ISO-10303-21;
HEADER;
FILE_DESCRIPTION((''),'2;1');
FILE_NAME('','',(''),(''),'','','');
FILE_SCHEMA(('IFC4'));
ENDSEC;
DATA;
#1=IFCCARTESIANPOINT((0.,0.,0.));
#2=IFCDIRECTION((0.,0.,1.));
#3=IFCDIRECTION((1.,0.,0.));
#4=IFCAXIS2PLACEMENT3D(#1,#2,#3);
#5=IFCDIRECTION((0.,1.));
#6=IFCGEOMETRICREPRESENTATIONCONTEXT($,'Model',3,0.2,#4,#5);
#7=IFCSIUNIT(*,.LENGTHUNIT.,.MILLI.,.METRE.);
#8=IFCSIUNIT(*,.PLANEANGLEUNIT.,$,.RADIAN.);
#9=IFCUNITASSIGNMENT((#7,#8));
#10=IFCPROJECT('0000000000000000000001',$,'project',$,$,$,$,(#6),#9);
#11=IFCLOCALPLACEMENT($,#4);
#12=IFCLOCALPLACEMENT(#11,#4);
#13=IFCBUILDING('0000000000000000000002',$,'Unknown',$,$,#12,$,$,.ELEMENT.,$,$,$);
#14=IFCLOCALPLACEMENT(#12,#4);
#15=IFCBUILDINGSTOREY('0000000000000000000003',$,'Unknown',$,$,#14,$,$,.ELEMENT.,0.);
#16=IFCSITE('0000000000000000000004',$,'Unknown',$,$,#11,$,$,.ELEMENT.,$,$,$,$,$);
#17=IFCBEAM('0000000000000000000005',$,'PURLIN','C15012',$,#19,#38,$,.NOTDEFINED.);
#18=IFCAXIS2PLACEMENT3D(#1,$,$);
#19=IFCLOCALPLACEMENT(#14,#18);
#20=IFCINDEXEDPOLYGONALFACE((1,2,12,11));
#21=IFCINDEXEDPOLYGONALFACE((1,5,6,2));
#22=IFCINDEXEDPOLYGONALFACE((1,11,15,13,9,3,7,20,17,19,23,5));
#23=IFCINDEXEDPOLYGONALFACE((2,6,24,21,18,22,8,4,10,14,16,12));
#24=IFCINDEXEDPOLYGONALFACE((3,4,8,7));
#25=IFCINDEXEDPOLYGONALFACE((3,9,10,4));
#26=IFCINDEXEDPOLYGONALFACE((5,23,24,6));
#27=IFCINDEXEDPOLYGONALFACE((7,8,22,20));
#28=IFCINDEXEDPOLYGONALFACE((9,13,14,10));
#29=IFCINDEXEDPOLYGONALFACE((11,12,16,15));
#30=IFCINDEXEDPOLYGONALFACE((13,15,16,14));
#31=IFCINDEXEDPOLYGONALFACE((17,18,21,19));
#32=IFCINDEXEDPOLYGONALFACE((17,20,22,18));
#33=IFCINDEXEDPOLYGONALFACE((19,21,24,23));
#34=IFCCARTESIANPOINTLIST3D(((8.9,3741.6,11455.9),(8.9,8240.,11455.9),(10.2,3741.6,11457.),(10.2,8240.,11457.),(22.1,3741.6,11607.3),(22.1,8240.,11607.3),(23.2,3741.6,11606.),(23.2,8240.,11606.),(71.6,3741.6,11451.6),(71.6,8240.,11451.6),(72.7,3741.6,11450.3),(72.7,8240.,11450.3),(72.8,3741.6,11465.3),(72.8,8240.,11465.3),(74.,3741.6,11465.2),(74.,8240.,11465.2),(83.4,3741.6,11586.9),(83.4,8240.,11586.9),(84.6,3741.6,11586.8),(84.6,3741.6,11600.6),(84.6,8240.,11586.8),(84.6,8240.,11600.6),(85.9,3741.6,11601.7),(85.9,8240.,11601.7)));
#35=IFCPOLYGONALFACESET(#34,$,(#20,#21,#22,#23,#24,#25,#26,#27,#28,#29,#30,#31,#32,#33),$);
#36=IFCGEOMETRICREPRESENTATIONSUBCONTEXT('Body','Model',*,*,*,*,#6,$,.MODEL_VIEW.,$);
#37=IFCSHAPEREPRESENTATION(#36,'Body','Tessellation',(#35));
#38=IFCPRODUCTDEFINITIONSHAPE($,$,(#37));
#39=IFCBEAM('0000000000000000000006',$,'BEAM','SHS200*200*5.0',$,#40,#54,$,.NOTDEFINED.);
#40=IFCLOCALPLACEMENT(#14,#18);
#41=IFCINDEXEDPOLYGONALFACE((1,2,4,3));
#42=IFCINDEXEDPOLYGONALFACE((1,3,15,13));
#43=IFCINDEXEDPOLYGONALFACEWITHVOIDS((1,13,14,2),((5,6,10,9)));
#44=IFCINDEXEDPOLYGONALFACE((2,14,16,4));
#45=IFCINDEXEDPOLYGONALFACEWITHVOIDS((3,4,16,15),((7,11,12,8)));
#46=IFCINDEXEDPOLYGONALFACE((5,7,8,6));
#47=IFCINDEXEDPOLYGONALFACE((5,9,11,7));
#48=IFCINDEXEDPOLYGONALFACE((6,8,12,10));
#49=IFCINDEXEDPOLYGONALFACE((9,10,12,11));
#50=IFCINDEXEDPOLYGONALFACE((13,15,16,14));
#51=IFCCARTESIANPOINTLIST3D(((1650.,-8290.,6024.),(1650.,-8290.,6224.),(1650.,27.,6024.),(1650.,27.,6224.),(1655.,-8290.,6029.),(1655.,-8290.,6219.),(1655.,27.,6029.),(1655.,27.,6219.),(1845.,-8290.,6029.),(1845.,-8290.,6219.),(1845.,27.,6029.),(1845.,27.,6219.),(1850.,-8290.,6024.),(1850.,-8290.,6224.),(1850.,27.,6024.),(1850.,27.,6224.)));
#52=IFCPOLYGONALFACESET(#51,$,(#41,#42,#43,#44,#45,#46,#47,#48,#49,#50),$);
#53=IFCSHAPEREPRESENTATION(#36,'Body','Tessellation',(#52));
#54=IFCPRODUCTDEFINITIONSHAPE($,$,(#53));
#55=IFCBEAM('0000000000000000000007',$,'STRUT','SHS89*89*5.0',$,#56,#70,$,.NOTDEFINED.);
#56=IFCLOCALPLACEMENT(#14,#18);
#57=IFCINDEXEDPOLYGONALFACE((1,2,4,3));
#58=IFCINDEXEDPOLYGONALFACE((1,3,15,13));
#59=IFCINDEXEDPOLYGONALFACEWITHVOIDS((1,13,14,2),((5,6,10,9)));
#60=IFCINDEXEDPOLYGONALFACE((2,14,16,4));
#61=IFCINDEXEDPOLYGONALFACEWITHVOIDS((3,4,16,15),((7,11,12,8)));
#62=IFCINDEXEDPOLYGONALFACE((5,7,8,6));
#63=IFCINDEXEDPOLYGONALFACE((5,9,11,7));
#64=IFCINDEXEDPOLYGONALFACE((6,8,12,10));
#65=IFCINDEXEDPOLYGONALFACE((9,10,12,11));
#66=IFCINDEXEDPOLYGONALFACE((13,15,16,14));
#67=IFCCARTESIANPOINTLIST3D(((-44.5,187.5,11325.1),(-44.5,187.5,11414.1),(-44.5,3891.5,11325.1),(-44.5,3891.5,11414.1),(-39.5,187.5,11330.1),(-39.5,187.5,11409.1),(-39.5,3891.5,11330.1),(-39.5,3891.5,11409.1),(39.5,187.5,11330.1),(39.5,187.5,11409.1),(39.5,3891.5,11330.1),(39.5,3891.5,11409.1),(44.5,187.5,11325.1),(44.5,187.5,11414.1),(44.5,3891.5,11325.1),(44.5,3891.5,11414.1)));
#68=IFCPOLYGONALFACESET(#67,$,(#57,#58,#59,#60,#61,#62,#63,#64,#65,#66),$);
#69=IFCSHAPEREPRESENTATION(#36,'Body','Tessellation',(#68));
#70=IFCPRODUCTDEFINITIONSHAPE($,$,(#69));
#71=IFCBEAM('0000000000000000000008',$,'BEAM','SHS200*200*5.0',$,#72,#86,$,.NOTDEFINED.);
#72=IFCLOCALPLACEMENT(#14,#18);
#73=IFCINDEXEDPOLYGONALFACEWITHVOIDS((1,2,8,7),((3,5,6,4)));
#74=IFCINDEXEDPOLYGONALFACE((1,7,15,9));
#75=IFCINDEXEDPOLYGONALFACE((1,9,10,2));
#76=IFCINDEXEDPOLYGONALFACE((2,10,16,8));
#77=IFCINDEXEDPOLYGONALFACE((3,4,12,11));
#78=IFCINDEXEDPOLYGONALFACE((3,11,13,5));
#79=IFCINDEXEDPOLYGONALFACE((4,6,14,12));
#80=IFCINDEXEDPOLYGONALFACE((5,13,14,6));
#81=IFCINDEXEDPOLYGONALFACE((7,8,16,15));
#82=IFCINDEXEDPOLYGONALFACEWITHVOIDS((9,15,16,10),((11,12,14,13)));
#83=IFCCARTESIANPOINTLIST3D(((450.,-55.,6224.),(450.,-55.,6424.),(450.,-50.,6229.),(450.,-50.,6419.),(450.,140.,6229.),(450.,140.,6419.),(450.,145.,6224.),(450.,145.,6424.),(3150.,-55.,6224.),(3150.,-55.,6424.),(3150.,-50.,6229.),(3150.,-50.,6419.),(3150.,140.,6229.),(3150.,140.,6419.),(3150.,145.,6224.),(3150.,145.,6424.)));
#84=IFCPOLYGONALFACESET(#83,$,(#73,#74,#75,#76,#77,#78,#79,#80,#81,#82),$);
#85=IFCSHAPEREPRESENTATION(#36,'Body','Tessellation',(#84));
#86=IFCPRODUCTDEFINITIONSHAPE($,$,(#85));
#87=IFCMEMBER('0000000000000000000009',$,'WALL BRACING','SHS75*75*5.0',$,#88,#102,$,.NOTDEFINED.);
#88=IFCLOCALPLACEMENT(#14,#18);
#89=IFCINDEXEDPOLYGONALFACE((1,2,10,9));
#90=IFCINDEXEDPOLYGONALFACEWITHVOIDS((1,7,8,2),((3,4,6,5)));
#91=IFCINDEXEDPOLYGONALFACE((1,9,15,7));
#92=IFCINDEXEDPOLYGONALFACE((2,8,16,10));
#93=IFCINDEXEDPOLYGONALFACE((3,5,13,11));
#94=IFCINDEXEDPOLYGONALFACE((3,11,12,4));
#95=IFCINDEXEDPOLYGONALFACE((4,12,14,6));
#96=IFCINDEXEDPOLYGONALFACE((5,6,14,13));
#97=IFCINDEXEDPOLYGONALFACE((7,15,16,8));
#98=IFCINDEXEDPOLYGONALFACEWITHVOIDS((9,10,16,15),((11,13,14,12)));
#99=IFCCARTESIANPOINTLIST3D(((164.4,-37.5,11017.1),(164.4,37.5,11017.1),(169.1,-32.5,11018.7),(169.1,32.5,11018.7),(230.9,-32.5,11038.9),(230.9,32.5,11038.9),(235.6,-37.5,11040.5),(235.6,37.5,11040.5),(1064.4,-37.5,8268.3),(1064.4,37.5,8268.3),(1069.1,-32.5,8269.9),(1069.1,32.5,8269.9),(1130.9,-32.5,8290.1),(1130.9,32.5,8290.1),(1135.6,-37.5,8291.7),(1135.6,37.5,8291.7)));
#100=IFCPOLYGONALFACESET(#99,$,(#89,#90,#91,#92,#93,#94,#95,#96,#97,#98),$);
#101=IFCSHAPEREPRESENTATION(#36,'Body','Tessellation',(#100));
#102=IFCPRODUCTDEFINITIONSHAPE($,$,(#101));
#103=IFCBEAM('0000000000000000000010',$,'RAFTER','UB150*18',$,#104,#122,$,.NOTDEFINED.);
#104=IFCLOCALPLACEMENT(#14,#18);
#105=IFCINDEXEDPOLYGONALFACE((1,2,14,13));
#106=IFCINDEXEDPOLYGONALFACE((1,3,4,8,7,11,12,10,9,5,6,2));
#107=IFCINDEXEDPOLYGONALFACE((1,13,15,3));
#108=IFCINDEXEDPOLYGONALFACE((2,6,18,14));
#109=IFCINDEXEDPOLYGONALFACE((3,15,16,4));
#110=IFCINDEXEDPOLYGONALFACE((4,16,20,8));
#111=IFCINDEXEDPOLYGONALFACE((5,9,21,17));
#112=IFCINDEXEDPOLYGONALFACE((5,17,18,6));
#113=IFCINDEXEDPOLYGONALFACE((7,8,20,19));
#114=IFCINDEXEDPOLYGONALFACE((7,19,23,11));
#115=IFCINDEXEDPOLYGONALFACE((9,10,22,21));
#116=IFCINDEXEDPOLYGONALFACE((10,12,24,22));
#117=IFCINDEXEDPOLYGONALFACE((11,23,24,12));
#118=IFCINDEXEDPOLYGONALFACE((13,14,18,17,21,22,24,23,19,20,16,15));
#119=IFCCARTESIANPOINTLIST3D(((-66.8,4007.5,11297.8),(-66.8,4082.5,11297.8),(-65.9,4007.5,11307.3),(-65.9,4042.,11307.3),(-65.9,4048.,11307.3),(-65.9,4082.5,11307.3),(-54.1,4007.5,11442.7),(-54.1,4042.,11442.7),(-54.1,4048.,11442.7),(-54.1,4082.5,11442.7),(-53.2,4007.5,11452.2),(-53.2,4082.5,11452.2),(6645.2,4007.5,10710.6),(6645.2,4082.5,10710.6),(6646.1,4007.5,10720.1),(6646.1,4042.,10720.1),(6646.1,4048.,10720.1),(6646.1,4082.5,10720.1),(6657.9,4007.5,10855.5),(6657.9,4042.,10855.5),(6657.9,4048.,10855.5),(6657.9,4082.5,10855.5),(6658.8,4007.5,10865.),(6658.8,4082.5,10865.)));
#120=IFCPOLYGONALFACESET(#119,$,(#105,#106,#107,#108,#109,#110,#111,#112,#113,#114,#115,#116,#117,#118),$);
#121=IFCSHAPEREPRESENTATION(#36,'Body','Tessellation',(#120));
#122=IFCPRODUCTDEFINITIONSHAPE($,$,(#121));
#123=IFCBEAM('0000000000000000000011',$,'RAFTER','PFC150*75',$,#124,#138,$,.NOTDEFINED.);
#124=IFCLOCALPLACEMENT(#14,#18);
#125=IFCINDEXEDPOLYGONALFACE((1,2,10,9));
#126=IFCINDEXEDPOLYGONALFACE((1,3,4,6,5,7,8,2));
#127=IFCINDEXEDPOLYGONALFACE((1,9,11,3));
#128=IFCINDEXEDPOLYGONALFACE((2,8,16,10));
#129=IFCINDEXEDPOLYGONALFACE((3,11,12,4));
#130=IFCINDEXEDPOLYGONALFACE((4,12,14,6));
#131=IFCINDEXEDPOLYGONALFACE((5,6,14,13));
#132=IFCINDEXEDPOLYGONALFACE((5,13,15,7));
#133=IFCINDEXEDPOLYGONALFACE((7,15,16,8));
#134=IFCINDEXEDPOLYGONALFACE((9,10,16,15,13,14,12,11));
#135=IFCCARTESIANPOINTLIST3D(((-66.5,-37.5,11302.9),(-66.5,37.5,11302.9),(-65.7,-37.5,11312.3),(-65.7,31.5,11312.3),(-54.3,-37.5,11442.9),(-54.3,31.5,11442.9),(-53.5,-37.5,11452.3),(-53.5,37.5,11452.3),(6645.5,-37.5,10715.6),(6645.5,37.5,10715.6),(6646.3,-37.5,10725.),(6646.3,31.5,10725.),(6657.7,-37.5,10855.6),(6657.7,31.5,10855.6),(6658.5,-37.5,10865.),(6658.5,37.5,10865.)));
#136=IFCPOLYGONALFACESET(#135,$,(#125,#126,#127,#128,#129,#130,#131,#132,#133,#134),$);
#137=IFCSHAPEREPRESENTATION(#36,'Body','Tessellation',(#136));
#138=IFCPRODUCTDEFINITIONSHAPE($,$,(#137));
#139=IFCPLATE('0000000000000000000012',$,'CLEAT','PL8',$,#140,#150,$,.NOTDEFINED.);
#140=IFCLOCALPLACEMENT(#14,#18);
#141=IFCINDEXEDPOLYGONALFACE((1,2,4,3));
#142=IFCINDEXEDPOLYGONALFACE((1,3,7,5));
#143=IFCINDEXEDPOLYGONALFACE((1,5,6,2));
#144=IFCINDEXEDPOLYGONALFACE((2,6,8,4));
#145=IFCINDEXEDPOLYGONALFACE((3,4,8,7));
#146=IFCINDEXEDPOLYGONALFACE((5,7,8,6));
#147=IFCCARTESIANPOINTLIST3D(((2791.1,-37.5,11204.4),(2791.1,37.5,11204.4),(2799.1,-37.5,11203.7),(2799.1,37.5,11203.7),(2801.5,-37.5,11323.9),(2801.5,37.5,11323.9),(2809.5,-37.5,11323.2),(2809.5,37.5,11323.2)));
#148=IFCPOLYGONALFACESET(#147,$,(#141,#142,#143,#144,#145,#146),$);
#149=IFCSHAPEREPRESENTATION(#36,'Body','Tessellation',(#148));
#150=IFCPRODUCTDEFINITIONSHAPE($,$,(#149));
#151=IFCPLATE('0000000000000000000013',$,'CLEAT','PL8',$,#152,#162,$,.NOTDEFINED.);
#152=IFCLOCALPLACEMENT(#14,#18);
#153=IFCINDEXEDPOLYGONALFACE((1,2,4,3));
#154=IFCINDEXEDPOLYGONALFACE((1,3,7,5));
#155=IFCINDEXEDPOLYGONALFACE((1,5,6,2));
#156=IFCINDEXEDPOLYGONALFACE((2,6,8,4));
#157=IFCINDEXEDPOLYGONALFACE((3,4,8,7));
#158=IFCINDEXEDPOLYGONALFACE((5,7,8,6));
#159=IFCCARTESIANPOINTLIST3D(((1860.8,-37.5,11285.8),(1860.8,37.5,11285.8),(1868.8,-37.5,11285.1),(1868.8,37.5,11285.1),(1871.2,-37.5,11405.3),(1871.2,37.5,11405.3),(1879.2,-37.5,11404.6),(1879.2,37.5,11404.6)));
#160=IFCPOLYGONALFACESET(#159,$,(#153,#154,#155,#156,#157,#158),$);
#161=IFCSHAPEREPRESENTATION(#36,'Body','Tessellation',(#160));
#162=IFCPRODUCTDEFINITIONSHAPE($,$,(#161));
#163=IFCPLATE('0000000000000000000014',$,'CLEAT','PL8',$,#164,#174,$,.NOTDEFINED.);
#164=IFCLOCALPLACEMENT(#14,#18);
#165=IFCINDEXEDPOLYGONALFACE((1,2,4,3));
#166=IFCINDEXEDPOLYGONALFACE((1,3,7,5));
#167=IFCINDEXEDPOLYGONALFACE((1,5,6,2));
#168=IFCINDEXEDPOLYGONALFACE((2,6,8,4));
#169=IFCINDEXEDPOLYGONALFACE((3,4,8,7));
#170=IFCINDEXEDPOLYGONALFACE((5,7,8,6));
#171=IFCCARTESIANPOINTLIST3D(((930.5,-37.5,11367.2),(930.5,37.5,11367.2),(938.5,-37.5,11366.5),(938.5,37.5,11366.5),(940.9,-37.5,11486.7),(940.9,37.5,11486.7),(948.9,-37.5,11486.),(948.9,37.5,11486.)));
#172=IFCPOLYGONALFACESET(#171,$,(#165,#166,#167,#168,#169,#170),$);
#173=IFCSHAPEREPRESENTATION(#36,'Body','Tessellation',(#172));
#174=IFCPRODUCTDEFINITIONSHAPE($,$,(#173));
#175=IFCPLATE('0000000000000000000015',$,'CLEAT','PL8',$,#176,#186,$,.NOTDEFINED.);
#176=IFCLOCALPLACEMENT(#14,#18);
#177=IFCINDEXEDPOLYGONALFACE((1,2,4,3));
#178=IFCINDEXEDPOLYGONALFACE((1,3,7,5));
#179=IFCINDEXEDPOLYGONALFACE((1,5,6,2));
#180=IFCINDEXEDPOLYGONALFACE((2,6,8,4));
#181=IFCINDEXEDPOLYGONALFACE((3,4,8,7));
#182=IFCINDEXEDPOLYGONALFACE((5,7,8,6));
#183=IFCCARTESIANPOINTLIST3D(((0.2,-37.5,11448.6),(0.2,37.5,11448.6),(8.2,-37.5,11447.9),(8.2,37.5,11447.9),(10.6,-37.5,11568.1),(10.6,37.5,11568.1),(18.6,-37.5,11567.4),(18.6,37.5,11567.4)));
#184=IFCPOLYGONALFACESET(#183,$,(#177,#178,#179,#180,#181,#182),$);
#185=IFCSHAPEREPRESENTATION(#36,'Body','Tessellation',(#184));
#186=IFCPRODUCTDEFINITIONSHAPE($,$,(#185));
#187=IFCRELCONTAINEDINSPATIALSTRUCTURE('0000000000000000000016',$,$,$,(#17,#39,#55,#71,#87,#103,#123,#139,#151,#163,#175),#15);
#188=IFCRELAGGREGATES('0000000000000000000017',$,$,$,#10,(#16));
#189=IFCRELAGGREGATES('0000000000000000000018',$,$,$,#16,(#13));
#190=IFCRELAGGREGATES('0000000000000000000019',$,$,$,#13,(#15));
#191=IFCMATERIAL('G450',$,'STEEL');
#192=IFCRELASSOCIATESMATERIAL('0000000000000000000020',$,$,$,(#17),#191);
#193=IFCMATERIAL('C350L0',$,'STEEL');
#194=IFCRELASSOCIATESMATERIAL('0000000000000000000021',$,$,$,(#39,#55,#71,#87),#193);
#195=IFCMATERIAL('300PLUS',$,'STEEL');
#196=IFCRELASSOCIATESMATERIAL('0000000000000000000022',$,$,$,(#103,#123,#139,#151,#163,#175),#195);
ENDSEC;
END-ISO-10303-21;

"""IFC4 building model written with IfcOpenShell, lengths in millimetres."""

from ifc_helpers import new_model, si_unit, direction, frame, origin_with_axes, place, context, subcontext, project, spatial, line, indexed_curve, outline, extrude, material, element, save


model = new_model("IFC4")

# Units and contexts
model_context = context("Model", 3, precision=0.2, world=origin_with_axes(), true_north=direction((0.0, 1.0)))
body_context = subcontext(model_context, "Body", "Model", "MODEL_VIEW")
ifc_project = project(units=[si_unit("LENGTHUNIT", "METRE", prefix="MILLI"), si_unit("PLANEANGLEUNIT", "RADIAN")], contexts=[model_context])

# Site, building, storey
site_placement = place(None, origin_with_axes())
site = spatial("IfcSite", under=ifc_project, at=site_placement, Name="Unknown", CompositionType="ELEMENT")
building_placement = place(site_placement, origin_with_axes())
building = spatial("IfcBuilding", under=site, at=building_placement, Name="Unknown", CompositionType="ELEMENT")
storey_placement = place(building_placement, origin_with_axes())
storey = spatial("IfcBuildingStorey", under=building, at=storey_placement, Name="Unknown", CompositionType="ELEMENT", Elevation=0.0)

# Shared definitions
ifc_material_1 = material(Name="C350L0", Category="STEEL")

# Beams
ifc_material_2 = material(Name="G450", Category="STEEL")
for number, where, z_axis, x_axis, name in (
    (1, (47.4, 3741.6, 11528.8), (0.996195, 0.0, -0.087156), (0.0, 1.0, 0.0), "PURLIN"),
):
    element("IfcBeam", number, at=place(storey_placement, frame(where, z_axis=z_axis, x_axis=x_axis)), inside=storey, material=ifc_material_2, Name=name, Description="C15012", PredefinedType="NOTDEFINED", context=body_context, shape_type="SolidModel", body=[
        extrude(outline(indexed_curve([(32.0, -76.0), (32.0, -61.0), (30.8, -61.0), (30.8, -74.8), (-30.8, -74.8), (-30.8, 74.8), (30.8, 74.8), (30.8, 61.0), (32.0, 61.0), (32.0, 76.0), (-32.0, 76.0), (-32.0, -76.0)], segments=[line(1, 2, 3, 4, 5, 6, 7, 8, 9, 10, 11, 12, 1)])), frame((0.0, 0.0, 0.0), z_axis=(-1.0, 0.0, 0.0), x_axis=(0.0, 0.0, 1.0)), (0.0, 0.0, -1.0), 4498.4),
    ])
beam_1_placement = place(storey_placement, frame((1750.0, 27.0, 6124.0), z_axis=(0.0, 0.0, 1.0), x_axis=(0.0, -1.0, 0.0)))
element("IfcBeam", 2, at=beam_1_placement, inside=storey, material=ifc_material_1, Name="BEAM", Description="SHS200*200*5.0", PredefinedType="NOTDEFINED", context=body_context, shape_type="SolidModel", body=[
    extrude(outline(indexed_curve([(-100.0, -100.0), (100.0, -100.0), (100.0, 100.0), (-100.0, 100.0)], segments=[line(1, 2, 3, 4, 1)]), holes=[indexed_curve([(-95.0, -95.0), (-95.0, 95.0), (95.0, 95.0), (95.0, -95.0)], segments=[line(1, 2, 3, 4, 1)])]), frame((0.0, 0.0, 0.0), z_axis=(-1.0, 0.0, 0.0), x_axis=(0.0, 0.0, 1.0)), (0.0, 0.0, -1.0), 8317.0),
])
beam_2_placement = place(storey_placement, frame((0.0, 187.5, 11369.6), z_axis=(0.0, 0.0, 1.0), x_axis=(0.0, 1.0, 0.0)))
element("IfcBeam", 3, at=beam_2_placement, inside=storey, material=ifc_material_1, Name="STRUT", Description="SHS89*89*5.0", PredefinedType="NOTDEFINED", context=body_context, shape_type="SolidModel", body=[
    extrude(outline(indexed_curve([(-44.5, -44.5), (44.5, -44.5), (44.5, 44.5), (-44.5, 44.5)], segments=[line(1, 2, 3, 4, 1)]), holes=[indexed_curve([(-39.5, -39.5), (-39.5, 39.5), (39.5, 39.5), (39.5, -39.5)], segments=[line(1, 2, 3, 4, 1)])]), frame((0.0, 0.0, 0.0), z_axis=(-1.0, 0.0, 0.0), x_axis=(0.0, 0.0, 1.0)), (0.0, 0.0, -1.0), 3704.0),
])
beam_3_placement = place(storey_placement, frame((450.0, 45.0, 6324.0), z_axis=(0.0, 0.0, 1.0), x_axis=(1.0, 0.0, 0.0)))
element("IfcBeam", 4, at=beam_3_placement, inside=storey, material=ifc_material_1, Name="BEAM", Description="SHS200*200*5.0", PredefinedType="NOTDEFINED", context=body_context, shape_type="SolidModel", body=[
    extrude(outline(indexed_curve([(-100.0, -100.0), (100.0, -100.0), (100.0, 100.0), (-100.0, 100.0)], segments=[line(1, 2, 3, 4, 1)]), holes=[indexed_curve([(-95.0, -95.0), (-95.0, 95.0), (95.0, 95.0), (95.0, -95.0)], segments=[line(1, 2, 3, 4, 1)])]), frame((0.0, 0.0, 0.0), z_axis=(-1.0, 0.0, 0.0), x_axis=(0.0, 0.0, 1.0)), (0.0, 0.0, -1.0), 2700.0),
])

# Member
member_placement = place(storey_placement, frame((200.0, 0.0, 11028.8), z_axis=(0.950357, 0.0, 0.311162), x_axis=(0.311162, 0.0, -0.950357)))
element("IfcMember", 5, at=member_placement, inside=storey, material=ifc_material_1, Name="WALL BRACING", Description="SHS75*75*5.0", PredefinedType="NOTDEFINED", context=body_context, shape_type="SolidModel", body=[
    extrude(outline(indexed_curve([(-37.5, -37.5), (37.5, -37.5), (37.5, 37.5), (-37.5, 37.5)], segments=[line(1, 2, 3, 4, 1)]), holes=[indexed_curve([(-32.5, -32.5), (-32.5, 32.5), (32.5, 32.5), (32.5, -32.5)], segments=[line(1, 2, 3, 4, 1)])]), frame((0.0, 0.0, 0.0), z_axis=(-1.0, 0.0, 0.0), x_axis=(0.0, 0.0, 1.0)), (0.0, 0.0, -1.0), 2892.4),
])

# Beams
ifc_material_3 = material(Name="300PLUS", Category="STEEL")
beam_4_placement = place(storey_placement, frame((-60.0, 4045.0, 11375.0), z_axis=(0.0, -1.0, 0.0), x_axis=(0.996195, 0.0, -0.087152)))
element("IfcBeam", 6, at=beam_4_placement, inside=storey, material=ifc_material_3, Name="RAFTER", Description="UB150*18", PredefinedType="NOTDEFINED", context=body_context, shape_type="SolidModel", body=[
    extrude(outline(indexed_curve([(-37.5, -77.5), (37.5, -77.5), (37.5, -68.0), (3.0, -68.0), (3.0, 68.0), (37.5, 68.0), (37.5, 77.5), (-37.5, 77.5), (-37.5, 68.0), (-3.0, 68.0), (-3.0, -68.0), (-37.5, -68.0)], segments=[line(1, 2, 3, 4, 5, 6, 7, 8, 9, 10, 11, 12, 1)])), frame((0.0, 0.0, 0.0), z_axis=(-1.0, 0.0, 0.0), x_axis=(0.0, 0.0, 1.0)), (0.0, 0.0, -1.0), 6737.6),
])
beam_5_placement = place(storey_placement, frame((-60.0, 0.0, 11377.6), z_axis=(0.0, -1.0, 0.0), x_axis=(0.996194, 0.0, -0.087167)))
element("IfcBeam", 7, at=beam_5_placement, inside=storey, material=ifc_material_3, Name="RAFTER", Description="PFC150*75", PredefinedType="NOTDEFINED", context=body_context, shape_type="SolidModel", body=[
    extrude(outline(indexed_curve([(-37.5, -75.0), (37.5, -75.0), (37.5, -65.5), (-31.5, -65.5), (-31.5, 65.5), (37.5, 65.5), (37.5, 75.0), (-37.5, 75.0)], segments=[line(1, 2, 3, 4, 5, 6, 7, 8, 1)])), frame((0.0, 0.0, 0.0), z_axis=(-1.0, 0.0, 0.0), x_axis=(0.0, 0.0, 1.0)), (0.0, 0.0, -1.0), 6737.6),
])

# Plates
for number, where, z_axis, x_axis, name in (
    (8, (2795.1, 37.5, 11204.0), (-0.996234, 0.0, 0.086702), (0.0, -1.0, 0.0), "CLEAT"),
    (9, (1864.8, 37.5, 11285.4), (-0.996234, 0.0, 0.086702), (0.0, -1.0, 0.0), "CLEAT"),
    (10, (934.5, 37.5, 11366.8), (-0.996234, 0.0, 0.086702), (0.0, -1.0, 0.0), "CLEAT"),
    (11, (4.2, 37.5, 11448.2), (-0.996234, 0.0, 0.086702), (0.0, -1.0, 0.0), "CLEAT"),
):
    element("IfcPlate", number, at=place(storey_placement, frame(where, z_axis=z_axis, x_axis=x_axis)), inside=storey, material=ifc_material_3, Name=name, Description="PL8", PredefinedType="NOTDEFINED", context=body_context, shape_type="SolidModel", body=[
        extrude(outline(indexed_curve([(0.0, 0.0), (75.0, 0.0), (75.0, 120.0), (0.0, 120.0)], segments=[line(1, 2, 3, 4, 1)])), frame((0.0, 0.0, 4.0), z_axis=(0.0, 0.0, 1.0), x_axis=(1.0, 0.0, 0.0)), (0.0, 0.0, -1.0), 8.0),
    ])

save(model, "model.ifc")
